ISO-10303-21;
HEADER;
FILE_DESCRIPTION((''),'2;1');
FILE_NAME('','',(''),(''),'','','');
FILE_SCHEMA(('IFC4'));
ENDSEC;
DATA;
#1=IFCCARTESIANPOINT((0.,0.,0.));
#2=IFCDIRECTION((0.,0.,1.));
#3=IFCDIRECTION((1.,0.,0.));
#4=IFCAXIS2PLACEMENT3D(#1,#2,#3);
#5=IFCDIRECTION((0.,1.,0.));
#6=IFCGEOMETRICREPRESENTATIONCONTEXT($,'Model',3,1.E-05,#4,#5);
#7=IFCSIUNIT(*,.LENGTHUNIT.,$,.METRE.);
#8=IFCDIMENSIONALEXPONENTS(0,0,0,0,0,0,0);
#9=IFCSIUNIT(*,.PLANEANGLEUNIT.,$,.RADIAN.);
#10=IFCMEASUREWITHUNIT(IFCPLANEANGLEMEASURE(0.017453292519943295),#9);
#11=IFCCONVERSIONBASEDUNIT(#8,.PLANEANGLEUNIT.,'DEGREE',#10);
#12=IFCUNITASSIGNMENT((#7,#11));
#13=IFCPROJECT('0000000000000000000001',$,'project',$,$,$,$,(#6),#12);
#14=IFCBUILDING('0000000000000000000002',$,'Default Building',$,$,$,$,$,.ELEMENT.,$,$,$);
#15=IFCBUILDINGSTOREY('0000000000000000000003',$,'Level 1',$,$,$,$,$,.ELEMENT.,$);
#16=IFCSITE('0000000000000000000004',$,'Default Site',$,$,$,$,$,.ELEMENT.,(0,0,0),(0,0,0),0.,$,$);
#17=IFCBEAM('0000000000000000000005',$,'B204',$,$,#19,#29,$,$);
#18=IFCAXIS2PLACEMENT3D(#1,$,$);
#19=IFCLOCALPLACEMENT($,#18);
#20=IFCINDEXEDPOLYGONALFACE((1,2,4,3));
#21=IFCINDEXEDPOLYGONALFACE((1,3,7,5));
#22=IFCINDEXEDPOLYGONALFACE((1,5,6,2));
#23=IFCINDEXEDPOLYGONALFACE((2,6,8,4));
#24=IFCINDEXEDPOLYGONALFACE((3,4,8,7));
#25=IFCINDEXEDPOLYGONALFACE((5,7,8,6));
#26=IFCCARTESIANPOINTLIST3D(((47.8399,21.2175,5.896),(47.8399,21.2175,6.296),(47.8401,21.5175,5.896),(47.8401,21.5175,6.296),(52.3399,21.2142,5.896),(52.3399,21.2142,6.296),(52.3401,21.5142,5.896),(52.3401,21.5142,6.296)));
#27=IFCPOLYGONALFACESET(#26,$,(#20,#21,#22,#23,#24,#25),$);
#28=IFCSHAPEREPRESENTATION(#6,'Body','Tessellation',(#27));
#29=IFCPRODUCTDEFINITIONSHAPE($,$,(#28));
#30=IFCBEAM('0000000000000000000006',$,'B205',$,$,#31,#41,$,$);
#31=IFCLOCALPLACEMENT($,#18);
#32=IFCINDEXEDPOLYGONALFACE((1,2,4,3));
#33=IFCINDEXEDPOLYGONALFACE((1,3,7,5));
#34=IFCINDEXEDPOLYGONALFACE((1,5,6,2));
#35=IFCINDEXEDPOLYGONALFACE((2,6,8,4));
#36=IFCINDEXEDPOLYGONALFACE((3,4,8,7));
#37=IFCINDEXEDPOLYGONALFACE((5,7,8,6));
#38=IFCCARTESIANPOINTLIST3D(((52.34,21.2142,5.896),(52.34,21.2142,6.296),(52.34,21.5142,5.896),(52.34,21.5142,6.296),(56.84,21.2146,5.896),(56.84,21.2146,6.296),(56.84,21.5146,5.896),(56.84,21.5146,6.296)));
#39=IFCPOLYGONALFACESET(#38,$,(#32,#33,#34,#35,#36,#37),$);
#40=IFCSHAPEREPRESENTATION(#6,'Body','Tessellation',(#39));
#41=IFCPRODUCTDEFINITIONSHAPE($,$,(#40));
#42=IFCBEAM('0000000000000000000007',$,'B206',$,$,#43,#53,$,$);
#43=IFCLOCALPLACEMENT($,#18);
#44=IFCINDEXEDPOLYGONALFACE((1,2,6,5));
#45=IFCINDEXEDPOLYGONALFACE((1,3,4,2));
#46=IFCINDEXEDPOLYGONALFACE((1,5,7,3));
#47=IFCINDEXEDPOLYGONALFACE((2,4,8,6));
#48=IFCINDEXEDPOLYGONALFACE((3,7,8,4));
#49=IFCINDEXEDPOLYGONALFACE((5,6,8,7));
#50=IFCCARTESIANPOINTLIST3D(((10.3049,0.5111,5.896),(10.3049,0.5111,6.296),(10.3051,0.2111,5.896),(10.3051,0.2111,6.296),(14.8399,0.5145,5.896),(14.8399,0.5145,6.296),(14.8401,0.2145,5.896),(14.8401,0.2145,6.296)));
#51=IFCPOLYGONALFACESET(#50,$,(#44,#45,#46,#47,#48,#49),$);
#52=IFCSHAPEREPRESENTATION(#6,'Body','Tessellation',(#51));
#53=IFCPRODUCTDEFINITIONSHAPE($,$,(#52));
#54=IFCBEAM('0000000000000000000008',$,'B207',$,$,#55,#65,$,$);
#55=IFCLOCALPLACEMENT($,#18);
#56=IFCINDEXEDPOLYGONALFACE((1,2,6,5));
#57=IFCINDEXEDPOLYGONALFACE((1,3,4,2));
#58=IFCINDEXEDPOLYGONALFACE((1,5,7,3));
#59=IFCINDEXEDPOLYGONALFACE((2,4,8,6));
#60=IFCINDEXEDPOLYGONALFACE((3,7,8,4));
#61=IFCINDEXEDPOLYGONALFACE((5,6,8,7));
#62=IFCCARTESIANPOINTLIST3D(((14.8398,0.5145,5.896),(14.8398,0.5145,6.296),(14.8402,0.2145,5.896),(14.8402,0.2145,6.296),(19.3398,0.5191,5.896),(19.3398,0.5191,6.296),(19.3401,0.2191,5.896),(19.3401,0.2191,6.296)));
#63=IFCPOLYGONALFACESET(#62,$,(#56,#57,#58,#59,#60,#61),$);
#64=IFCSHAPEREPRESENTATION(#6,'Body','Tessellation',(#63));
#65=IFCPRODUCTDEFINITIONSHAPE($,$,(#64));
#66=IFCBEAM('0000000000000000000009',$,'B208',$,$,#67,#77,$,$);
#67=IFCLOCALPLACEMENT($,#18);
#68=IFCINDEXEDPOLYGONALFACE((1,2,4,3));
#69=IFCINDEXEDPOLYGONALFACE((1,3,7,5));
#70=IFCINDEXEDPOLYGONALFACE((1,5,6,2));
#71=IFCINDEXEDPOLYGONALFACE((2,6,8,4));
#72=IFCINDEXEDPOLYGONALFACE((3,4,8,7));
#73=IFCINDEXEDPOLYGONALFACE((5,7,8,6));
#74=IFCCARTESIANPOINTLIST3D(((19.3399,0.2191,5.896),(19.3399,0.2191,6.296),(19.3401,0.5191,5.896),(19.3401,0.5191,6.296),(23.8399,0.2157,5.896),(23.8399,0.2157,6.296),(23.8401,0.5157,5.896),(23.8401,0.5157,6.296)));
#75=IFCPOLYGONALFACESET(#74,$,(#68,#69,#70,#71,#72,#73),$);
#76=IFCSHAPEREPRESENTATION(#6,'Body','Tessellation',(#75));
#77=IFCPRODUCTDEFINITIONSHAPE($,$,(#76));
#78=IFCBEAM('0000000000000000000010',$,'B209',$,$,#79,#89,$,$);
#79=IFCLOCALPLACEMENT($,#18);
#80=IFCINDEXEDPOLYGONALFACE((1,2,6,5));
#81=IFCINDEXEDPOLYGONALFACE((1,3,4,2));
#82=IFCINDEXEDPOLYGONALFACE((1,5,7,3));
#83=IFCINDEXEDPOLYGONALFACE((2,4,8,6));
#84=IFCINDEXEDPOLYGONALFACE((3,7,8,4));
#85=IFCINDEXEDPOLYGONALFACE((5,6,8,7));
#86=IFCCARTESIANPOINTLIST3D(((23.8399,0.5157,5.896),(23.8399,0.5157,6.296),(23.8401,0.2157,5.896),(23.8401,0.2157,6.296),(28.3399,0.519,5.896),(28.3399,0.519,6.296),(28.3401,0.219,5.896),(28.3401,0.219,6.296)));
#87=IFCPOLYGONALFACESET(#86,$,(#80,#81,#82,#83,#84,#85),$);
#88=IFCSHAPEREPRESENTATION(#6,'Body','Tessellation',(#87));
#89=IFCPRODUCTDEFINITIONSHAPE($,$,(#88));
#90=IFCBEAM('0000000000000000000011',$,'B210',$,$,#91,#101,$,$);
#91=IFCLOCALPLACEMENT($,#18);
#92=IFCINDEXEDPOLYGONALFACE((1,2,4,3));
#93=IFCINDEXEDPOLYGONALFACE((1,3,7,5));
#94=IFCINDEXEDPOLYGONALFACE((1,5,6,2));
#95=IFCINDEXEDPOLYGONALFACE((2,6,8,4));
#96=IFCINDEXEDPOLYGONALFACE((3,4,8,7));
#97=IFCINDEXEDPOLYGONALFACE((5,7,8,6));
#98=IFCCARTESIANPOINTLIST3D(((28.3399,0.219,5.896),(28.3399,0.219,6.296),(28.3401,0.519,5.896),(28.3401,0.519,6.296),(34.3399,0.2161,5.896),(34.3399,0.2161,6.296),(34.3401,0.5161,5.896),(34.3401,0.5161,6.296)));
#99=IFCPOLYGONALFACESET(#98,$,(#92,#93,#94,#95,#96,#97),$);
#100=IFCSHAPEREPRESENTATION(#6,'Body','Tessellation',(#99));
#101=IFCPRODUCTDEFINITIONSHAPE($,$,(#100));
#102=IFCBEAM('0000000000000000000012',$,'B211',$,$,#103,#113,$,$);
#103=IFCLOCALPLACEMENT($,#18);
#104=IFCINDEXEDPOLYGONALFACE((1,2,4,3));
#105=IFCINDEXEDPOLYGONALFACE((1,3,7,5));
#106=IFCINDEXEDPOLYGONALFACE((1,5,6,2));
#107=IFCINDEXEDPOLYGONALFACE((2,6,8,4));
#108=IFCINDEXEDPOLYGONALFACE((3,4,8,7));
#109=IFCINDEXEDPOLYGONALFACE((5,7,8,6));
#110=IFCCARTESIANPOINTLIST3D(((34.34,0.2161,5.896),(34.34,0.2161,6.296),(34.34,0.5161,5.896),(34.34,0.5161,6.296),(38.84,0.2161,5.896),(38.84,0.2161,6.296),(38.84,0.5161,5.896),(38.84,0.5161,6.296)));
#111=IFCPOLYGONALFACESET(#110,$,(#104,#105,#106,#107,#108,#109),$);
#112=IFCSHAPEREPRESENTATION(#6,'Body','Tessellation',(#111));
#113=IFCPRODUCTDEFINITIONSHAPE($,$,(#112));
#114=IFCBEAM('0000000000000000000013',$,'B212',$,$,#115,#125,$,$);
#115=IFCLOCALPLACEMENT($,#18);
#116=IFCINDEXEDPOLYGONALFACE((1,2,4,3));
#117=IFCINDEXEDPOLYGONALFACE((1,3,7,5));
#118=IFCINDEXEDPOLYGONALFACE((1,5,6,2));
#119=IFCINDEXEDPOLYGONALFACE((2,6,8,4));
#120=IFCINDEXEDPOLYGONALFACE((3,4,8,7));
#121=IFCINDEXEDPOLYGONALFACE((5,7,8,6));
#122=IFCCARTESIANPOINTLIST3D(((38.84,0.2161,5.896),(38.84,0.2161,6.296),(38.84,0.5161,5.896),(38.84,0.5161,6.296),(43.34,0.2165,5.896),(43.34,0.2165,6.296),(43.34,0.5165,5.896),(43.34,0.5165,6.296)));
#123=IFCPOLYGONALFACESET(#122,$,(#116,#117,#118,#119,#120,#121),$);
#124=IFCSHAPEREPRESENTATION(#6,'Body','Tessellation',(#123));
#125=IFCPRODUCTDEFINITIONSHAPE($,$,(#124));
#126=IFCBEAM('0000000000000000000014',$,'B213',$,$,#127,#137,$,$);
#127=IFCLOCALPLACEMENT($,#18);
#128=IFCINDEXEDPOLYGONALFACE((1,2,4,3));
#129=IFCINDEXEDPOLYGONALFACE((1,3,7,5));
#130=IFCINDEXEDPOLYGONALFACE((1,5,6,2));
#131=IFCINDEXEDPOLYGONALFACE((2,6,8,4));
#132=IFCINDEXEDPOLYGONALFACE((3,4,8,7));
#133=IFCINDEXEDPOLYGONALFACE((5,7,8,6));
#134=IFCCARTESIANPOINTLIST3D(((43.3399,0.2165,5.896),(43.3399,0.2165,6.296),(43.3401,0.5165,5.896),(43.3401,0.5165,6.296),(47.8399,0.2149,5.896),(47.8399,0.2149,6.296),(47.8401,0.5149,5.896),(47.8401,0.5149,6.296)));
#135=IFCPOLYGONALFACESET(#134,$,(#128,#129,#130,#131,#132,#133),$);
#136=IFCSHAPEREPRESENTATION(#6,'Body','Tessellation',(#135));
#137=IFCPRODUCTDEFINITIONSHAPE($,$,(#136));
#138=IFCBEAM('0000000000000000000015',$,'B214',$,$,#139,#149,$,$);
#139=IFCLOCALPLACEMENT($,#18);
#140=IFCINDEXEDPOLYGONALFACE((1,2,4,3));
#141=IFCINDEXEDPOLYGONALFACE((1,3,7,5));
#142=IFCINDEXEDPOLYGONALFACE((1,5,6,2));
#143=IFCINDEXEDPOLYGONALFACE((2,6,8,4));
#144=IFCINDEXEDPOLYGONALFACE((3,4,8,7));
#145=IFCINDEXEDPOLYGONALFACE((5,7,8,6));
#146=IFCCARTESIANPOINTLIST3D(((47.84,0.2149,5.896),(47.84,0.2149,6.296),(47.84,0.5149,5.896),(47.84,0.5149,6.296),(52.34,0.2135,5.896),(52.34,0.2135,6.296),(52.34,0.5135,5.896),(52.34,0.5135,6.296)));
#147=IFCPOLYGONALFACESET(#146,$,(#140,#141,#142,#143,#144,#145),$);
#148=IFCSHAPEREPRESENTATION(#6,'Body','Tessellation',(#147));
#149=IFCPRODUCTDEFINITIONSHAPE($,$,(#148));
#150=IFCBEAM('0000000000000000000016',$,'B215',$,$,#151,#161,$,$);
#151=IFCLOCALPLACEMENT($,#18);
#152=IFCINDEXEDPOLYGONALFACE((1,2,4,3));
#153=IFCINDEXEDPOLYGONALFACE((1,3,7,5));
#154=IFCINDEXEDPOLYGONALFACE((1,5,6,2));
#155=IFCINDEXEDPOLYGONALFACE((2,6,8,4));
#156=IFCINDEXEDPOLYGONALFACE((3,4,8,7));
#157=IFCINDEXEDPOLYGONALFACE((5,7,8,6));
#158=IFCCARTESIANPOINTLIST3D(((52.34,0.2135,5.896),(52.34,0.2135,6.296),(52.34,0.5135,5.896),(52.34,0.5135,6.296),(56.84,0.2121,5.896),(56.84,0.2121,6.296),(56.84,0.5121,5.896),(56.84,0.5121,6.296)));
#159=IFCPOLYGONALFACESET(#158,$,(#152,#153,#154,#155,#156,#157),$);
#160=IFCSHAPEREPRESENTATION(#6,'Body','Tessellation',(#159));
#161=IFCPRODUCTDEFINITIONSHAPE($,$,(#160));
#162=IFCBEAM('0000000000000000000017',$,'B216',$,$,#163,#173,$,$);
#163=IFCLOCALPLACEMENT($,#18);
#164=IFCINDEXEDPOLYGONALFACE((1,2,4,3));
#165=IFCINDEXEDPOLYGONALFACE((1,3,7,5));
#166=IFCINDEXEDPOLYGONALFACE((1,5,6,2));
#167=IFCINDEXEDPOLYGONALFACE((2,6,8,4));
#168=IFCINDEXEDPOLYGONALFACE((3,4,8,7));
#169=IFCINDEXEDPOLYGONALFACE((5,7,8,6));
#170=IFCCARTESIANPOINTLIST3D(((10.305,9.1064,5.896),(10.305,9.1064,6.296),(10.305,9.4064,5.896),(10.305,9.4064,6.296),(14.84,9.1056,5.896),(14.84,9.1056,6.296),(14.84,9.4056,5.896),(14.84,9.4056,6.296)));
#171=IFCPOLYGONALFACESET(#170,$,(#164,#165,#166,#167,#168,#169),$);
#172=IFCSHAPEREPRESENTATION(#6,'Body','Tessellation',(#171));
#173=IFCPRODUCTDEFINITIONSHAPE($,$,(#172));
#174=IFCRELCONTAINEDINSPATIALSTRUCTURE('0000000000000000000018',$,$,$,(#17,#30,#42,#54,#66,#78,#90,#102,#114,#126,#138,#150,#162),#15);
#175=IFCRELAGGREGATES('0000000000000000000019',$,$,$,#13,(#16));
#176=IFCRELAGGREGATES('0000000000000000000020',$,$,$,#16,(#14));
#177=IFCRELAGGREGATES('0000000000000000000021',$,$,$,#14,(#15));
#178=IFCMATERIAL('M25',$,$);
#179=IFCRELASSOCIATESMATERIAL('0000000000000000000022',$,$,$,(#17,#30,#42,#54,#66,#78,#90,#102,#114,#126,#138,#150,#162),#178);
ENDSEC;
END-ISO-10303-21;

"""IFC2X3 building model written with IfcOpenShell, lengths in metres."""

from ifc_helpers import new_model, entity, si_unit, converted_unit, direction, frame, frame_2d, origin_with_axes, place, context, project, spatial, rectangle, extrude, material, element, save


model = new_model("IFC2X3")

# Units and contexts
model_context = context("Model", 3, precision=1e-05, world=origin_with_axes(), true_north=direction((0.0, 1.0, 0.0)))
ifc_project = project(units=[si_unit("LENGTHUNIT", "METRE"), converted_unit("PLANEANGLEUNIT", "DEGREE", entity("IfcPlaneAngleMeasure", 0.017453292519943295), si_unit("PLANEANGLEUNIT", "RADIAN"), dimensions=[0, 0, 0, 0, 0, 0, 0])], contexts=[model_context])

# Site, building, storey
site = spatial("IfcSite", under=ifc_project, Name="Default Site", CompositionType="ELEMENT", RefLatitude=(0, 0, 0), RefLongitude=(0, 0, 0), RefElevation=0.0)
building = spatial("IfcBuilding", under=site, Name="Default Building", CompositionType="ELEMENT")
storey = spatial("IfcBuildingStorey", under=building, Name="Level 1", CompositionType="ELEMENT")

# Shared definitions
ifc_material = material(Name="M25")
placement = place(None, origin_with_axes())

# Beams
element("IfcBeam", 1, at=placement, inside=storey, material=ifc_material, Name="B204", context=model_context, shape_type="SweptSolid", body=[
    extrude(rectangle(XDim=0.3, YDim=0.4, at=frame_2d((0.0, 0.0), x_axis=(0.0, 1.0, 0.0))), frame((47.84, 21.3675, 6.096), z_axis=(1.0, -0.000744, 0.0), x_axis=(0.0, 0.0, -1.0)), (0.0, 0.0, 1.0), 4.5),
])
element("IfcBeam", 2, at=placement, inside=storey, material=ifc_material, Name="B205", context=model_context, shape_type="SweptSolid", body=[
    extrude(rectangle(XDim=0.3, YDim=0.4, at=frame_2d((0.0, 0.0), x_axis=(0.0, 1.0, 0.0))), frame((52.34, 21.3642, 6.096), z_axis=(1.0, 0.000102, 0.0), x_axis=(0.0, 0.0, -1.0)), (0.0, 0.0, 1.0), 4.5),
])
element("IfcBeam", 3, at=placement, inside=storey, material=ifc_material, Name="B206", context=model_context, shape_type="SweptSolid", body=[
    extrude(rectangle(XDim=0.3, YDim=0.4, at=frame_2d((0.0, 0.0), x_axis=(0.0, 1.0, 0.0))), frame((10.305, 0.3611, 6.096), z_axis=(1.0, 0.000762, 0.0), x_axis=(0.0, 0.0, -1.0)), (0.0, 0.0, 1.0), 4.535),
])
element("IfcBeam", 4, at=placement, inside=storey, material=ifc_material, Name="B207", context=model_context, shape_type="SweptSolid", body=[
    extrude(rectangle(XDim=0.3, YDim=0.4, at=frame_2d((0.0, 0.0), x_axis=(0.0, 1.0, 0.0))), frame((14.84, 0.3645, 6.096), z_axis=(0.999999, 0.00101, 0.0), x_axis=(0.0, 0.0, -1.0)), (0.0, 0.0, 1.0), 4.5),
])
element("IfcBeam", 5, at=placement, inside=storey, material=ifc_material, Name="B208", context=model_context, shape_type="SweptSolid", body=[
    extrude(rectangle(XDim=0.3, YDim=0.4, at=frame_2d((0.0, 0.0), x_axis=(0.0, 1.0, 0.0))), frame((19.34, 0.3691, 6.096), z_axis=(1.0, -0.000757, 0.0), x_axis=(0.0, 0.0, -1.0)), (0.0, 0.0, 1.0), 4.5),
])
element("IfcBeam", 6, at=placement, inside=storey, material=ifc_material, Name="B209", context=model_context, shape_type="SweptSolid", body=[
    extrude(rectangle(XDim=0.3, YDim=0.4, at=frame_2d((0.0, 0.0), x_axis=(0.0, 1.0, 0.0))), frame((23.84, 0.3657, 6.096), z_axis=(1.0, 0.00075, 0.0), x_axis=(0.0, 0.0, -1.0)), (0.0, 0.0, 1.0), 4.5),
])
element("IfcBeam", 7, at=placement, inside=storey, material=ifc_material, Name="B210", context=model_context, shape_type="SweptSolid", body=[
    extrude(rectangle(XDim=0.3, YDim=0.4, at=frame_2d((0.0, 0.0), x_axis=(0.0, 1.0, 0.0))), frame((28.34, 0.369, 6.096), z_axis=(1.0, -0.000487, 0.0), x_axis=(0.0, 0.0, -1.0)), (0.0, 0.0, 1.0), 6.0),
])
element("IfcBeam", 8, at=placement, inside=storey, material=ifc_material, Name="B211", context=model_context, shape_type="SweptSolid", body=[
    extrude(rectangle(XDim=0.3, YDim=0.4, at=frame_2d((0.0, 0.0), x_axis=(0.0, 1.0, 0.0))), frame((34.34, 0.3661, 6.096), z_axis=(1.0, 0.000003, 0.0), x_axis=(0.0, 0.0, -1.0)), (0.0, 0.0, 1.0), 4.5),
])
element("IfcBeam", 9, at=placement, inside=storey, material=ifc_material, Name="B212", context=model_context, shape_type="SweptSolid", body=[
    extrude(rectangle(XDim=0.3, YDim=0.4, at=frame_2d((0.0, 0.0), x_axis=(0.0, 1.0, 0.0))), frame((38.84, 0.3661, 6.096), z_axis=(1.0, 0.000077, 0.0), x_axis=(0.0, 0.0, -1.0)), (0.0, 0.0, 1.0), 4.5),
])
element("IfcBeam", 10, at=placement, inside=storey, material=ifc_material, Name="B213", context=model_context, shape_type="SweptSolid", body=[
    extrude(rectangle(XDim=0.3, YDim=0.4, at=frame_2d((0.0, 0.0), x_axis=(0.0, 1.0, 0.0))), frame((43.34, 0.3665, 6.096), z_axis=(1.0, -0.000358, 0.0), x_axis=(0.0, 0.0, -1.0)), (0.0, 0.0, 1.0), 4.5),
])
element("IfcBeam", 11, at=placement, inside=storey, material=ifc_material, Name="B214", context=model_context, shape_type="SweptSolid", body=[
    extrude(rectangle(XDim=0.3, YDim=0.4, at=frame_2d((0.0, 0.0), x_axis=(0.0, 1.0, 0.0))), frame((47.84, 0.3649, 6.096), z_axis=(1.0, -0.000297, 0.0), x_axis=(0.0, 0.0, -1.0)), (0.0, 0.0, 1.0), 4.5),
])
element("IfcBeam", 12, at=placement, inside=storey, material=ifc_material, Name="B215", context=model_context, shape_type="SweptSolid", body=[
    extrude(rectangle(XDim=0.3, YDim=0.4, at=frame_2d((0.0, 0.0), x_axis=(0.0, 1.0, 0.0))), frame((52.34, 0.3635, 6.096), z_axis=(1.0, -0.000311, 0.0), x_axis=(0.0, 0.0, -1.0)), (0.0, 0.0, 1.0), 4.5),
])
element("IfcBeam", 13, at=placement, inside=storey, material=ifc_material, Name="B216", context=model_context, shape_type="SweptSolid", body=[
    extrude(rectangle(XDim=0.3, YDim=0.4, at=frame_2d((0.0, 0.0), x_axis=(0.0, 1.0, 0.0))), frame((10.305, 9.2564, 6.096), z_axis=(1.0, -0.000182, 0.0), x_axis=(0.0, 0.0, -1.0)), (0.0, 0.0, 1.0), 4.535),
])

save(model, "model.ifc")
